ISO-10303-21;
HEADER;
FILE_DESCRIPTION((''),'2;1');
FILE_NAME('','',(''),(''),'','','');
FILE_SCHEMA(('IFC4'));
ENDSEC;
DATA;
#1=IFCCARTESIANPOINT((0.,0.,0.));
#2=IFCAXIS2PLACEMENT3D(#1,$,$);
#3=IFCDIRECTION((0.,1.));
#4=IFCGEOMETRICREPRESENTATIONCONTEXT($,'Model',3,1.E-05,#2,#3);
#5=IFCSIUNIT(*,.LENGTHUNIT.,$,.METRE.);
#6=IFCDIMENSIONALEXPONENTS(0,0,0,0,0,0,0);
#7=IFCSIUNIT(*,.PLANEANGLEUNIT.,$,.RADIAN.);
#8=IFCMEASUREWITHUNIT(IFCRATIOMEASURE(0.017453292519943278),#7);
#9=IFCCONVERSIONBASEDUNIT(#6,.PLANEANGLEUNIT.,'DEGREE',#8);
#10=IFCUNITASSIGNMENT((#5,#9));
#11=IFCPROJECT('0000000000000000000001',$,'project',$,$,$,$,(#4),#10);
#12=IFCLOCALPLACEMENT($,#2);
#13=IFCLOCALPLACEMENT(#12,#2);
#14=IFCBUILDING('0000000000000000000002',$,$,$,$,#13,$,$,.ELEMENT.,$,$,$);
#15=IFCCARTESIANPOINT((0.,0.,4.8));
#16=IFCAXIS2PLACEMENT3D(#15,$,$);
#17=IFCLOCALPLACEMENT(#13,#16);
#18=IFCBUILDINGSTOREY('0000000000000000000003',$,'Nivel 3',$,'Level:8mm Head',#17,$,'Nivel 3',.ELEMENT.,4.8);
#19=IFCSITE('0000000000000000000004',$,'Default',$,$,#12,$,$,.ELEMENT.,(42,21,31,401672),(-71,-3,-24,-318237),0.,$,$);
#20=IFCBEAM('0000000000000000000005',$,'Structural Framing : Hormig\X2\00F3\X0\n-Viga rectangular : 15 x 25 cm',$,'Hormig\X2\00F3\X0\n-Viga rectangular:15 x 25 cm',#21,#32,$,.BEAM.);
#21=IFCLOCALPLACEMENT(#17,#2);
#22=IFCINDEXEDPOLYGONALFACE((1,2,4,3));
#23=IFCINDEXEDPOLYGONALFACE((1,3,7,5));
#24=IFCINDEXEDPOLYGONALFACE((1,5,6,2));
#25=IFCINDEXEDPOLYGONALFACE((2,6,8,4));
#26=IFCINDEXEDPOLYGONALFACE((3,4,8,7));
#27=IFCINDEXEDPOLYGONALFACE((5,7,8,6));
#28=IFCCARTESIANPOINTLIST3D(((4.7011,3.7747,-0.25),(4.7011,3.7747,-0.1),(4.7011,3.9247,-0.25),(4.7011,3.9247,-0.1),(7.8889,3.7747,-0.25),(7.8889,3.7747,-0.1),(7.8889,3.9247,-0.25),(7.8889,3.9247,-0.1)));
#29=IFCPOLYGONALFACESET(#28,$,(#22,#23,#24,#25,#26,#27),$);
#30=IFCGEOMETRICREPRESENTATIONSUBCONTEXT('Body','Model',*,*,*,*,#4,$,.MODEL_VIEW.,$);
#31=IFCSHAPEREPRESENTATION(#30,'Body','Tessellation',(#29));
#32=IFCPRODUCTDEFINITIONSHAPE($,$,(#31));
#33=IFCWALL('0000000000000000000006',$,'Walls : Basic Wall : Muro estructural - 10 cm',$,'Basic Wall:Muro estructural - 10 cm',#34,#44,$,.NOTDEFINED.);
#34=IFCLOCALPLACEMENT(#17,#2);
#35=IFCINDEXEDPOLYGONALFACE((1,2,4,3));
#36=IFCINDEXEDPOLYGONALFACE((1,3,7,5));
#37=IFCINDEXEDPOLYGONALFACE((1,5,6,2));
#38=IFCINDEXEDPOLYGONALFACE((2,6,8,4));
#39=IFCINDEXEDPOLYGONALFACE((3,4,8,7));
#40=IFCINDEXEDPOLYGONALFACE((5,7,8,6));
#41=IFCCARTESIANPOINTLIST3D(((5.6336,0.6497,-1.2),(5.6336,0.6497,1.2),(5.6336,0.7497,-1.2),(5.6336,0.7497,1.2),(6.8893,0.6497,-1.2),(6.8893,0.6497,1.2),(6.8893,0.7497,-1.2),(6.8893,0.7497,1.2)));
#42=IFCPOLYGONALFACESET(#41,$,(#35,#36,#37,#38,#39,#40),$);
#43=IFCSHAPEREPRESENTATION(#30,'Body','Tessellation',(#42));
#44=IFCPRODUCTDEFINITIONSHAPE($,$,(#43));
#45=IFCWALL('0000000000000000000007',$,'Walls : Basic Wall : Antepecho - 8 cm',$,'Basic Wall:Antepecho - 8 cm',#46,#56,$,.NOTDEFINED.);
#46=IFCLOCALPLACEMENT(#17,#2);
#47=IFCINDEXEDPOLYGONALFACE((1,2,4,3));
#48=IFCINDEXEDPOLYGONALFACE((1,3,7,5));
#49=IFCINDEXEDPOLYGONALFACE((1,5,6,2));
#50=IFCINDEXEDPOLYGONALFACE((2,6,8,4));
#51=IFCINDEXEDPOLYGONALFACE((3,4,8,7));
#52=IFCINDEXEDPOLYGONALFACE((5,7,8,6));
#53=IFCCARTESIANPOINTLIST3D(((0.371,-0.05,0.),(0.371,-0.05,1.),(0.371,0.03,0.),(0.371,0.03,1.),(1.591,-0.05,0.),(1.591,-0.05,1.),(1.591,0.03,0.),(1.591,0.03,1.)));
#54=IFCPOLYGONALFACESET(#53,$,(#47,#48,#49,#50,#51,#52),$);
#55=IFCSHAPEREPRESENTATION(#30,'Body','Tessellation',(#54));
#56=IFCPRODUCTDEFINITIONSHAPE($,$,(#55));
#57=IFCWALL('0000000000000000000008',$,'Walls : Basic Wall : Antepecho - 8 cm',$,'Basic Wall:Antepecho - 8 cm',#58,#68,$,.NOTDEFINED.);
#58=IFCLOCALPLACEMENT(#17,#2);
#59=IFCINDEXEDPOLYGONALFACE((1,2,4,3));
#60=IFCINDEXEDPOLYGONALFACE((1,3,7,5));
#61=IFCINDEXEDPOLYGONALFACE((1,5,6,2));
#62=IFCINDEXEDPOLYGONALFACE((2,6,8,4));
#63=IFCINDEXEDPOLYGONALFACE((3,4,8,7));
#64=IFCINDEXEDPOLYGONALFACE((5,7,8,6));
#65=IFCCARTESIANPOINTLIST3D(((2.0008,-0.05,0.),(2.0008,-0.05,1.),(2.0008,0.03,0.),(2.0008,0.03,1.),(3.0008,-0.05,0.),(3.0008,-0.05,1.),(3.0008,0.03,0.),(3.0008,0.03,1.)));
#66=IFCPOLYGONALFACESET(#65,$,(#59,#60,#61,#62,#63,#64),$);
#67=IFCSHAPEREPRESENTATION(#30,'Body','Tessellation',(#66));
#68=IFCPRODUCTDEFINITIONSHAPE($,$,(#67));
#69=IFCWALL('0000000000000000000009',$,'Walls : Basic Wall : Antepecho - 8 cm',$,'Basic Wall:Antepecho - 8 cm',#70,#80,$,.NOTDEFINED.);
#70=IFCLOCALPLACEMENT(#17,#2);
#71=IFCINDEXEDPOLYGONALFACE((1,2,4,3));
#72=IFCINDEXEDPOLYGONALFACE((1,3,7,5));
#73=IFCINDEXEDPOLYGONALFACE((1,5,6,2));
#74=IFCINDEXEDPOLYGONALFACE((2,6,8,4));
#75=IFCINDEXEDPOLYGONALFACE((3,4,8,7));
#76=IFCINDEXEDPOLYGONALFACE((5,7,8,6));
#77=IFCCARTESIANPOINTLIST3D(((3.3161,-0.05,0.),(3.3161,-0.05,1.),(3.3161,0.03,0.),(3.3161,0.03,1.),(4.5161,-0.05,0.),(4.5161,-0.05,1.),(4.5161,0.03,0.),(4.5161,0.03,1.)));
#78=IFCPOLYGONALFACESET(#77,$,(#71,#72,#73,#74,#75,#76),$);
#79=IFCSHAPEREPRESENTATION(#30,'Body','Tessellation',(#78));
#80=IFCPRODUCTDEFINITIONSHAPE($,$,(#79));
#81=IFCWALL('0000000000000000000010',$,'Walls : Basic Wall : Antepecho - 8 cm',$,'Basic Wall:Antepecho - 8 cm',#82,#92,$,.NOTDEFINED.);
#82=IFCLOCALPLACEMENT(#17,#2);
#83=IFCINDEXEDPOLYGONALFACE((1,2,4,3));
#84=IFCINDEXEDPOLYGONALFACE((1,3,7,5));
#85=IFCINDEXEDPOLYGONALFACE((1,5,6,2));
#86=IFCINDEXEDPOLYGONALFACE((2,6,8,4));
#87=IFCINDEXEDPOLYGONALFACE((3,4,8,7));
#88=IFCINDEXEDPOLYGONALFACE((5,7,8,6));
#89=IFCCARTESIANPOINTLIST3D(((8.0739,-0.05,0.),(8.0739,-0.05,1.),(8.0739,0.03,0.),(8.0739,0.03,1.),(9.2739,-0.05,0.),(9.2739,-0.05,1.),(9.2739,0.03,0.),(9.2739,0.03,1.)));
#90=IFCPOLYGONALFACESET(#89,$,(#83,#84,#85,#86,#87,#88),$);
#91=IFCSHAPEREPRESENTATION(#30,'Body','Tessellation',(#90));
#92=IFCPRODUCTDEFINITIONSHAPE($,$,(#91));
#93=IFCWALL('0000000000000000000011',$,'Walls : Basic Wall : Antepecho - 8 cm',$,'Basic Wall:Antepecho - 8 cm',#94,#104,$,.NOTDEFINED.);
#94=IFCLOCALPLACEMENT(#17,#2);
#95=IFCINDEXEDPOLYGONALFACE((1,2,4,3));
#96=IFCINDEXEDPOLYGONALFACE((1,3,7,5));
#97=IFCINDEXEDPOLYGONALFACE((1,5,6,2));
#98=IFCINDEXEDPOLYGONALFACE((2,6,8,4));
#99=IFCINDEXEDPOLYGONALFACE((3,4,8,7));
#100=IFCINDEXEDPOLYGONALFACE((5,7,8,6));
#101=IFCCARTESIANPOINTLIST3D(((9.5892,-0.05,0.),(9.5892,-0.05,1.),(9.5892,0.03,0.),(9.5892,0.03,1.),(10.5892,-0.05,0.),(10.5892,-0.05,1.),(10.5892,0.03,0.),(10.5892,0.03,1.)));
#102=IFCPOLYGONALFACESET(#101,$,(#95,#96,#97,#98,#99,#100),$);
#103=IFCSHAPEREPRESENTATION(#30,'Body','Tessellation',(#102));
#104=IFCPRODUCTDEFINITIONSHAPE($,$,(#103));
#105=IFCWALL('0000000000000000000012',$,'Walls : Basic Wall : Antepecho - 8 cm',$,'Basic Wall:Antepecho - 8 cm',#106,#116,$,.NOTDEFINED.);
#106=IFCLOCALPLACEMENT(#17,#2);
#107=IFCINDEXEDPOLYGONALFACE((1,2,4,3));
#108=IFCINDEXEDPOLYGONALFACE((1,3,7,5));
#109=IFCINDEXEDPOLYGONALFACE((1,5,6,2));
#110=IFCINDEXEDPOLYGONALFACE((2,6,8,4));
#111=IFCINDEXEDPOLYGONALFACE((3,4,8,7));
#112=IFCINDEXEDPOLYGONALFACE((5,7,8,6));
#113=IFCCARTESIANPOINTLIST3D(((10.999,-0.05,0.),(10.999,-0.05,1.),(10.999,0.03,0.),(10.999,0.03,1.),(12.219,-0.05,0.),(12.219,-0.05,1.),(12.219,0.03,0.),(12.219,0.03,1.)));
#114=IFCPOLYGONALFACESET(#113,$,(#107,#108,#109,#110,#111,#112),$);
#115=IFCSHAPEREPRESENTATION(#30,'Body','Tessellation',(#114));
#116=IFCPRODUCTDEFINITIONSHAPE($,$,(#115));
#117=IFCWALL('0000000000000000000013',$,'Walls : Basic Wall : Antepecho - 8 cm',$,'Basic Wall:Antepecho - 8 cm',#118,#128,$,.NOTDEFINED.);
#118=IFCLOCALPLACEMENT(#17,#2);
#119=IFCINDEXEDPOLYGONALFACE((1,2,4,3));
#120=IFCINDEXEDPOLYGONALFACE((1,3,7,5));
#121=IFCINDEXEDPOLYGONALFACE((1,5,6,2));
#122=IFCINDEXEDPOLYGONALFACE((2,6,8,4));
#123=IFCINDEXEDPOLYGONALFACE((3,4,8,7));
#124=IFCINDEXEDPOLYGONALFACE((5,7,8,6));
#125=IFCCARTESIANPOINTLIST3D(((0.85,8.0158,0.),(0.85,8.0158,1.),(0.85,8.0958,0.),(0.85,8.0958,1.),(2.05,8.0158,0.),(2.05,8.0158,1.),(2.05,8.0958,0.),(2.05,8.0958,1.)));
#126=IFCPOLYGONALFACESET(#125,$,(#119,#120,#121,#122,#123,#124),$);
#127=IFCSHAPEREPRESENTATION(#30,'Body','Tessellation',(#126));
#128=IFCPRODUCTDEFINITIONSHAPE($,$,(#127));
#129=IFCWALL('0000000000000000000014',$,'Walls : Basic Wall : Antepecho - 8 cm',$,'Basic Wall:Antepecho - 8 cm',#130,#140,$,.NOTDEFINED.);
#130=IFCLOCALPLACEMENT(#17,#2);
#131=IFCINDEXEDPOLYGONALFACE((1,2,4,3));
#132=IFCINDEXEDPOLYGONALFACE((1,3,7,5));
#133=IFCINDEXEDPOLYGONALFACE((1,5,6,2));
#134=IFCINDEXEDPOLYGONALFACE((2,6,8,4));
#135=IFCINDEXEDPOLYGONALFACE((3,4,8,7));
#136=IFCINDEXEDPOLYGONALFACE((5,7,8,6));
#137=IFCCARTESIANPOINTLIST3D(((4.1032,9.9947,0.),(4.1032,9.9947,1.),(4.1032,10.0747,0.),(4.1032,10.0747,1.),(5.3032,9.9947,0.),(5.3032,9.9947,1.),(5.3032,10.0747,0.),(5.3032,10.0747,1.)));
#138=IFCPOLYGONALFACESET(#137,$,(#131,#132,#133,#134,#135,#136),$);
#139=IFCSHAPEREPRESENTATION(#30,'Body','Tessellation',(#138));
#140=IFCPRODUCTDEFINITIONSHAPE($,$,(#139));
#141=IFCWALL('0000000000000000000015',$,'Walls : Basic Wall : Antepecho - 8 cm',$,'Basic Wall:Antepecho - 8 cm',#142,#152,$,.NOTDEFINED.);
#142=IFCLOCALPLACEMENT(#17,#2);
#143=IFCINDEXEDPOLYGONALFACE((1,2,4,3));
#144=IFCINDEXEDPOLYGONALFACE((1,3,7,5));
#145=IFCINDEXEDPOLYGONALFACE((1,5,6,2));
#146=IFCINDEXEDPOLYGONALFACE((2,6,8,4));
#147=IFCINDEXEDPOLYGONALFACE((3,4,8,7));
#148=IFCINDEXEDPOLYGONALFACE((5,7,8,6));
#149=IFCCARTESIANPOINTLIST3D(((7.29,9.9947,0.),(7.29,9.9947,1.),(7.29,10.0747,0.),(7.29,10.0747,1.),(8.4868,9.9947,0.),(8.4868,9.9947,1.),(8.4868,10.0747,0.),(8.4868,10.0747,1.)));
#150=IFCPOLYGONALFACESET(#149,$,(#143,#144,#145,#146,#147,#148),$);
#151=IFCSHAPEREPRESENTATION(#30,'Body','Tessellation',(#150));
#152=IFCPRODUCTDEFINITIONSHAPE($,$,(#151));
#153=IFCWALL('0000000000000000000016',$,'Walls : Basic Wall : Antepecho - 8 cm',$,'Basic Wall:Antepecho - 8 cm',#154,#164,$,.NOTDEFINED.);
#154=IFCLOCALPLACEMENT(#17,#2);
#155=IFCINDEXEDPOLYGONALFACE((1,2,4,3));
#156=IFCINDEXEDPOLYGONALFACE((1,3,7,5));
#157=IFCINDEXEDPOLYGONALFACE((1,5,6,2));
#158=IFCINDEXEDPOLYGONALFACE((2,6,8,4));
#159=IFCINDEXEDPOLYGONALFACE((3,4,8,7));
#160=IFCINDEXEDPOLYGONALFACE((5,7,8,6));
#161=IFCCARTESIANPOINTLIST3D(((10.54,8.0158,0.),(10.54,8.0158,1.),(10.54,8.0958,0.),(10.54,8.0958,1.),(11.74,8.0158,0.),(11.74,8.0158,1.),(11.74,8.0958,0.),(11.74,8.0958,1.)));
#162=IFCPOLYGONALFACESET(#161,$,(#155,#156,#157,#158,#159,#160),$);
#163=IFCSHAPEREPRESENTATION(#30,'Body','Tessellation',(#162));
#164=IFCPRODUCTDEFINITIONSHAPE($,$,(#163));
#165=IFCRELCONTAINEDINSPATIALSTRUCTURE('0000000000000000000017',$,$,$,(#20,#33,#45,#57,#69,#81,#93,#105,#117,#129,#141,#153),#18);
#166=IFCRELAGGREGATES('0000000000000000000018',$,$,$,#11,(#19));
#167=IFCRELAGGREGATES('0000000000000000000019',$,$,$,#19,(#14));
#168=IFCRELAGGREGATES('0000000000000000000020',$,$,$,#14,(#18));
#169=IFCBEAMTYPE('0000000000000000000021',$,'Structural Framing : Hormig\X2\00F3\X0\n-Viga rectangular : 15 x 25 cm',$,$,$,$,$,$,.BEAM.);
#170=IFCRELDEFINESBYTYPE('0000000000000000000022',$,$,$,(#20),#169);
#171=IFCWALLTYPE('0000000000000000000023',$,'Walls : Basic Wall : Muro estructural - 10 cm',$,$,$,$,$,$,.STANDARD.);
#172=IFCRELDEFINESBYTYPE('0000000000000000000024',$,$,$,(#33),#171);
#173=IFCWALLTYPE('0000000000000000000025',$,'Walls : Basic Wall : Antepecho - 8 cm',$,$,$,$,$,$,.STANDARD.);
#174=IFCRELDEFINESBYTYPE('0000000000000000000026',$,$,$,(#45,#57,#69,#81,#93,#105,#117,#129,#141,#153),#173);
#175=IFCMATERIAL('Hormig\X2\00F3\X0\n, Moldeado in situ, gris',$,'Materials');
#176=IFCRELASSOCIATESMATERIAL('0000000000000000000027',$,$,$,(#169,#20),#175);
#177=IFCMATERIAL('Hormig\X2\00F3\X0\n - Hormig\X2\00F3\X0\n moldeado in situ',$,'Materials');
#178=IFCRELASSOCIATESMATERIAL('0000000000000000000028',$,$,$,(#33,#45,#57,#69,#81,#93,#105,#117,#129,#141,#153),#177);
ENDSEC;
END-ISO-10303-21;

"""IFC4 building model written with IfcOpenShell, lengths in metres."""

from ifc_helpers import new_model, entity, si_unit, converted_unit, direction, frame, origin, place, context, subcontext, project, spatial, indexed_curve, outline, extrude, source, transform, mapped, material, type_object, type_shapes, element, save


model = new_model("IFC4")

# Units and contexts
model_context = context("Model", 3, precision=1e-05, world=origin(), true_north=direction((0.0, 1.0)))
body_context = subcontext(model_context, "Body", "Model", "MODEL_VIEW")
ifc_project = project(units=[si_unit("LENGTHUNIT", "METRE"), converted_unit("PLANEANGLEUNIT", "DEGREE", entity("IfcRatioMeasure", 0.017453292519943278), si_unit("PLANEANGLEUNIT", "RADIAN"), dimensions=[0, 0, 0, 0, 0, 0, 0])], contexts=[model_context])

# Site, building, storey
site_placement = place(None, origin())
site = spatial("IfcSite", under=ifc_project, at=site_placement, Name="Default", CompositionType="ELEMENT", RefLatitude=(42, 21, 31, 401672), RefLongitude=(-71, -3, -24, -318237), RefElevation=0.0)
building_placement = place(site_placement, origin())
building = spatial("IfcBuilding", under=site, at=building_placement, CompositionType="ELEMENT")
storey_placement = place(building_placement, frame((0.0, 0.0, 4.8)))
storey = spatial("IfcBuildingStorey", under=building, at=storey_placement, Name="Nivel 3", ObjectType="Level:8mm Head", LongName="Nivel 3", CompositionType="ELEMENT", Elevation=4.8)

# Beam
ifc_material_1 = material(Name="Hormigón, Moldeado in situ, gris", Category="Materials")
beam_type_1 = type_object("IfcBeamType", Name="Structural Framing : Hormigón-Viga rectangular : 15 x 25 cm", PredefinedType="BEAM", material=ifc_material_1)
shared_shape_1 = source(origin(), body_context, "Body", "SweptSolid", [
    extrude(outline(indexed_curve([(-0.075, -0.075), (0.075, -0.075), (0.075, 0.075), (-0.075, 0.075), (-0.075, -0.075)], self_intersect=False)), frame((4.7011, 3.8497, 4.625), z_axis=(1.0, 0.0, 0.0), x_axis=(0.0, 0.0, -1.0)), (0.0, 0.0, 1.0), 3.1878),
])
type_shapes(beam_type_1, [shared_shape_1])
beam_1_placement = place(storey_placement, frame((0.0, 0.0, -4.8)))
element("IfcBeam", 1, at=beam_1_placement, inside=storey, type_object=beam_type_1, material=ifc_material_1, Name="Structural Framing : Hormigón-Viga rectangular : 15 x 25 cm", ObjectType="Hormigón-Viga rectangular:15 x 25 cm", PredefinedType="BEAM", context=body_context, shape_type="MappedRepresentation", body=[
    mapped(shared_shape_1, transform((0.0, 0.0, 0.0), scale=1.0)),
])

# Shared definitions
ifc_material_2 = material(Name="Hormigón - Hormigón moldeado in situ", Category="Materials")

# Walls
wall_type_1 = type_object("IfcWallType", Name="Walls : Basic Wall : Muro estructural - 10 cm", PredefinedType="STANDARD")
wall_1_placement = place(storey_placement, frame((5.6336, 0.6997, -1.2)))
element("IfcWall", 2, at=wall_1_placement, inside=storey, type_object=wall_type_1, material=ifc_material_2, Name="Walls : Basic Wall : Muro estructural - 10 cm", ObjectType="Basic Wall:Muro estructural - 10 cm", PredefinedType="NOTDEFINED", context=body_context, shape_type="SweptSolid", body=[
    extrude(outline(indexed_curve([(1.2557, 0.05), (0.0, 0.05), (0.0, -0.05), (1.2557, -0.05), (1.2557, 0.05)], self_intersect=False)), origin(), (0.0, 0.0, 1.0), 2.4),
])
wall_type_2 = type_object("IfcWallType", Name="Walls : Basic Wall : Antepecho - 8 cm", PredefinedType="STANDARD")
wall_2_placement = place(storey_placement, frame((0.371, -0.01, 0.0)))
element("IfcWall", 3, at=wall_2_placement, inside=storey, type_object=wall_type_2, material=ifc_material_2, Name="Walls : Basic Wall : Antepecho - 8 cm", ObjectType="Basic Wall:Antepecho - 8 cm", PredefinedType="NOTDEFINED", context=body_context, shape_type="SweptSolid", body=[
    extrude(outline(indexed_curve([(1.22, 0.04), (0.0, 0.04), (0.0, -0.04), (1.22, -0.04), (1.22, 0.04)], self_intersect=False)), origin(), (0.0, 0.0, 1.0), 1.0),
])
wall_3_placement = place(storey_placement, frame((2.0008, -0.01, 0.0)))
element("IfcWall", 4, at=wall_3_placement, inside=storey, type_object=wall_type_2, material=ifc_material_2, Name="Walls : Basic Wall : Antepecho - 8 cm", ObjectType="Basic Wall:Antepecho - 8 cm", PredefinedType="NOTDEFINED", context=body_context, shape_type="SweptSolid", body=[
    extrude(outline(indexed_curve([(1.0, 0.04), (0.0, 0.04), (0.0, -0.04), (1.0, -0.04), (1.0, 0.04)], self_intersect=False)), origin(), (0.0, 0.0, 1.0), 1.0),
])
wall_4_placement = place(storey_placement, frame((3.3161, -0.01, 0.0)))
element("IfcWall", 5, at=wall_4_placement, inside=storey, type_object=wall_type_2, material=ifc_material_2, Name="Walls : Basic Wall : Antepecho - 8 cm", ObjectType="Basic Wall:Antepecho - 8 cm", PredefinedType="NOTDEFINED", context=body_context, shape_type="SweptSolid", body=[
    extrude(outline(indexed_curve([(1.2, 0.04), (0.0, 0.04), (0.0, -0.04), (1.2, -0.04), (1.2, 0.04)], self_intersect=False)), origin(), (0.0, 0.0, 1.0), 1.0),
])
wall_5_placement = place(storey_placement, frame((8.0739, -0.01, 0.0)))
element("IfcWall", 6, at=wall_5_placement, inside=storey, type_object=wall_type_2, material=ifc_material_2, Name="Walls : Basic Wall : Antepecho - 8 cm", ObjectType="Basic Wall:Antepecho - 8 cm", PredefinedType="NOTDEFINED", context=body_context, shape_type="SweptSolid", body=[
    extrude(outline(indexed_curve([(1.2, 0.04), (0.0, 0.04), (0.0, -0.04), (1.2, -0.04), (1.2, 0.04)], self_intersect=False)), origin(), (0.0, 0.0, 1.0), 1.0),
])
wall_6_placement = place(storey_placement, frame((9.5892, -0.01, 0.0)))
element("IfcWall", 7, at=wall_6_placement, inside=storey, type_object=wall_type_2, material=ifc_material_2, Name="Walls : Basic Wall : Antepecho - 8 cm", ObjectType="Basic Wall:Antepecho - 8 cm", PredefinedType="NOTDEFINED", context=body_context, shape_type="SweptSolid", body=[
    extrude(outline(indexed_curve([(1.0, 0.04), (0.0, 0.04), (0.0, -0.04), (1.0, -0.04), (1.0, 0.04)], self_intersect=False)), origin(), (0.0, 0.0, 1.0), 1.0),
])
wall_7_placement = place(storey_placement, frame((10.999, -0.01, 0.0)))
element("IfcWall", 8, at=wall_7_placement, inside=storey, type_object=wall_type_2, material=ifc_material_2, Name="Walls : Basic Wall : Antepecho - 8 cm", ObjectType="Basic Wall:Antepecho - 8 cm", PredefinedType="NOTDEFINED", context=body_context, shape_type="SweptSolid", body=[
    extrude(outline(indexed_curve([(1.22, 0.04), (0.0, 0.04), (0.0, -0.04), (1.22, -0.04), (1.22, 0.04)], self_intersect=False)), origin(), (0.0, 0.0, 1.0), 1.0),
])
wall_8_placement = place(storey_placement, frame((2.05, 8.0558, 0.0), z_axis=(0.0, 0.0, 1.0), x_axis=(-1.0, 0.0, 0.0)))
element("IfcWall", 9, at=wall_8_placement, inside=storey, type_object=wall_type_2, material=ifc_material_2, Name="Walls : Basic Wall : Antepecho - 8 cm", ObjectType="Basic Wall:Antepecho - 8 cm", PredefinedType="NOTDEFINED", context=body_context, shape_type="SweptSolid", body=[
    extrude(outline(indexed_curve([(1.2, 0.04), (0.0, 0.04), (0.0, -0.04), (1.2, -0.04), (1.2, 0.04)], self_intersect=False)), origin(), (0.0, 0.0, 1.0), 1.0),
])
wall_9_placement = place(storey_placement, frame((5.3032, 10.0347, 0.0), z_axis=(0.0, 0.0, 1.0), x_axis=(-1.0, 0.0, 0.0)))
element("IfcWall", 10, at=wall_9_placement, inside=storey, type_object=wall_type_2, material=ifc_material_2, Name="Walls : Basic Wall : Antepecho - 8 cm", ObjectType="Basic Wall:Antepecho - 8 cm", PredefinedType="NOTDEFINED", context=body_context, shape_type="SweptSolid", body=[
    extrude(outline(indexed_curve([(1.2, 0.04), (0.0, 0.04), (0.0, -0.04), (1.2, -0.04), (1.2, 0.04)], self_intersect=False)), origin(), (0.0, 0.0, 1.0), 1.0),
])
wall_10_placement = place(storey_placement, frame((8.4868, 10.0347, 0.0), z_axis=(0.0, 0.0, 1.0), x_axis=(-1.0, 0.0, 0.0)))
element("IfcWall", 11, at=wall_10_placement, inside=storey, type_object=wall_type_2, material=ifc_material_2, Name="Walls : Basic Wall : Antepecho - 8 cm", ObjectType="Basic Wall:Antepecho - 8 cm", PredefinedType="NOTDEFINED", context=body_context, shape_type="SweptSolid", body=[
    extrude(outline(indexed_curve([(1.1968, 0.04), (0.0, 0.04), (0.0, -0.04), (1.1968, -0.04), (1.1968, 0.04)], self_intersect=False)), origin(), (0.0, 0.0, 1.0), 1.0),
])
wall_11_placement = place(storey_placement, frame((11.74, 8.0558, 0.0), z_axis=(0.0, 0.0, 1.0), x_axis=(-1.0, 0.0, 0.0)))
element("IfcWall", 12, at=wall_11_placement, inside=storey, type_object=wall_type_2, material=ifc_material_2, Name="Walls : Basic Wall : Antepecho - 8 cm", ObjectType="Basic Wall:Antepecho - 8 cm", PredefinedType="NOTDEFINED", context=body_context, shape_type="SweptSolid", body=[
    extrude(outline(indexed_curve([(1.2, 0.04), (0.0, 0.04), (0.0, -0.04), (1.2, -0.04), (1.2, 0.04)], self_intersect=False)), origin(), (0.0, 0.0, 1.0), 1.0),
])

save(model, "model.ifc")
